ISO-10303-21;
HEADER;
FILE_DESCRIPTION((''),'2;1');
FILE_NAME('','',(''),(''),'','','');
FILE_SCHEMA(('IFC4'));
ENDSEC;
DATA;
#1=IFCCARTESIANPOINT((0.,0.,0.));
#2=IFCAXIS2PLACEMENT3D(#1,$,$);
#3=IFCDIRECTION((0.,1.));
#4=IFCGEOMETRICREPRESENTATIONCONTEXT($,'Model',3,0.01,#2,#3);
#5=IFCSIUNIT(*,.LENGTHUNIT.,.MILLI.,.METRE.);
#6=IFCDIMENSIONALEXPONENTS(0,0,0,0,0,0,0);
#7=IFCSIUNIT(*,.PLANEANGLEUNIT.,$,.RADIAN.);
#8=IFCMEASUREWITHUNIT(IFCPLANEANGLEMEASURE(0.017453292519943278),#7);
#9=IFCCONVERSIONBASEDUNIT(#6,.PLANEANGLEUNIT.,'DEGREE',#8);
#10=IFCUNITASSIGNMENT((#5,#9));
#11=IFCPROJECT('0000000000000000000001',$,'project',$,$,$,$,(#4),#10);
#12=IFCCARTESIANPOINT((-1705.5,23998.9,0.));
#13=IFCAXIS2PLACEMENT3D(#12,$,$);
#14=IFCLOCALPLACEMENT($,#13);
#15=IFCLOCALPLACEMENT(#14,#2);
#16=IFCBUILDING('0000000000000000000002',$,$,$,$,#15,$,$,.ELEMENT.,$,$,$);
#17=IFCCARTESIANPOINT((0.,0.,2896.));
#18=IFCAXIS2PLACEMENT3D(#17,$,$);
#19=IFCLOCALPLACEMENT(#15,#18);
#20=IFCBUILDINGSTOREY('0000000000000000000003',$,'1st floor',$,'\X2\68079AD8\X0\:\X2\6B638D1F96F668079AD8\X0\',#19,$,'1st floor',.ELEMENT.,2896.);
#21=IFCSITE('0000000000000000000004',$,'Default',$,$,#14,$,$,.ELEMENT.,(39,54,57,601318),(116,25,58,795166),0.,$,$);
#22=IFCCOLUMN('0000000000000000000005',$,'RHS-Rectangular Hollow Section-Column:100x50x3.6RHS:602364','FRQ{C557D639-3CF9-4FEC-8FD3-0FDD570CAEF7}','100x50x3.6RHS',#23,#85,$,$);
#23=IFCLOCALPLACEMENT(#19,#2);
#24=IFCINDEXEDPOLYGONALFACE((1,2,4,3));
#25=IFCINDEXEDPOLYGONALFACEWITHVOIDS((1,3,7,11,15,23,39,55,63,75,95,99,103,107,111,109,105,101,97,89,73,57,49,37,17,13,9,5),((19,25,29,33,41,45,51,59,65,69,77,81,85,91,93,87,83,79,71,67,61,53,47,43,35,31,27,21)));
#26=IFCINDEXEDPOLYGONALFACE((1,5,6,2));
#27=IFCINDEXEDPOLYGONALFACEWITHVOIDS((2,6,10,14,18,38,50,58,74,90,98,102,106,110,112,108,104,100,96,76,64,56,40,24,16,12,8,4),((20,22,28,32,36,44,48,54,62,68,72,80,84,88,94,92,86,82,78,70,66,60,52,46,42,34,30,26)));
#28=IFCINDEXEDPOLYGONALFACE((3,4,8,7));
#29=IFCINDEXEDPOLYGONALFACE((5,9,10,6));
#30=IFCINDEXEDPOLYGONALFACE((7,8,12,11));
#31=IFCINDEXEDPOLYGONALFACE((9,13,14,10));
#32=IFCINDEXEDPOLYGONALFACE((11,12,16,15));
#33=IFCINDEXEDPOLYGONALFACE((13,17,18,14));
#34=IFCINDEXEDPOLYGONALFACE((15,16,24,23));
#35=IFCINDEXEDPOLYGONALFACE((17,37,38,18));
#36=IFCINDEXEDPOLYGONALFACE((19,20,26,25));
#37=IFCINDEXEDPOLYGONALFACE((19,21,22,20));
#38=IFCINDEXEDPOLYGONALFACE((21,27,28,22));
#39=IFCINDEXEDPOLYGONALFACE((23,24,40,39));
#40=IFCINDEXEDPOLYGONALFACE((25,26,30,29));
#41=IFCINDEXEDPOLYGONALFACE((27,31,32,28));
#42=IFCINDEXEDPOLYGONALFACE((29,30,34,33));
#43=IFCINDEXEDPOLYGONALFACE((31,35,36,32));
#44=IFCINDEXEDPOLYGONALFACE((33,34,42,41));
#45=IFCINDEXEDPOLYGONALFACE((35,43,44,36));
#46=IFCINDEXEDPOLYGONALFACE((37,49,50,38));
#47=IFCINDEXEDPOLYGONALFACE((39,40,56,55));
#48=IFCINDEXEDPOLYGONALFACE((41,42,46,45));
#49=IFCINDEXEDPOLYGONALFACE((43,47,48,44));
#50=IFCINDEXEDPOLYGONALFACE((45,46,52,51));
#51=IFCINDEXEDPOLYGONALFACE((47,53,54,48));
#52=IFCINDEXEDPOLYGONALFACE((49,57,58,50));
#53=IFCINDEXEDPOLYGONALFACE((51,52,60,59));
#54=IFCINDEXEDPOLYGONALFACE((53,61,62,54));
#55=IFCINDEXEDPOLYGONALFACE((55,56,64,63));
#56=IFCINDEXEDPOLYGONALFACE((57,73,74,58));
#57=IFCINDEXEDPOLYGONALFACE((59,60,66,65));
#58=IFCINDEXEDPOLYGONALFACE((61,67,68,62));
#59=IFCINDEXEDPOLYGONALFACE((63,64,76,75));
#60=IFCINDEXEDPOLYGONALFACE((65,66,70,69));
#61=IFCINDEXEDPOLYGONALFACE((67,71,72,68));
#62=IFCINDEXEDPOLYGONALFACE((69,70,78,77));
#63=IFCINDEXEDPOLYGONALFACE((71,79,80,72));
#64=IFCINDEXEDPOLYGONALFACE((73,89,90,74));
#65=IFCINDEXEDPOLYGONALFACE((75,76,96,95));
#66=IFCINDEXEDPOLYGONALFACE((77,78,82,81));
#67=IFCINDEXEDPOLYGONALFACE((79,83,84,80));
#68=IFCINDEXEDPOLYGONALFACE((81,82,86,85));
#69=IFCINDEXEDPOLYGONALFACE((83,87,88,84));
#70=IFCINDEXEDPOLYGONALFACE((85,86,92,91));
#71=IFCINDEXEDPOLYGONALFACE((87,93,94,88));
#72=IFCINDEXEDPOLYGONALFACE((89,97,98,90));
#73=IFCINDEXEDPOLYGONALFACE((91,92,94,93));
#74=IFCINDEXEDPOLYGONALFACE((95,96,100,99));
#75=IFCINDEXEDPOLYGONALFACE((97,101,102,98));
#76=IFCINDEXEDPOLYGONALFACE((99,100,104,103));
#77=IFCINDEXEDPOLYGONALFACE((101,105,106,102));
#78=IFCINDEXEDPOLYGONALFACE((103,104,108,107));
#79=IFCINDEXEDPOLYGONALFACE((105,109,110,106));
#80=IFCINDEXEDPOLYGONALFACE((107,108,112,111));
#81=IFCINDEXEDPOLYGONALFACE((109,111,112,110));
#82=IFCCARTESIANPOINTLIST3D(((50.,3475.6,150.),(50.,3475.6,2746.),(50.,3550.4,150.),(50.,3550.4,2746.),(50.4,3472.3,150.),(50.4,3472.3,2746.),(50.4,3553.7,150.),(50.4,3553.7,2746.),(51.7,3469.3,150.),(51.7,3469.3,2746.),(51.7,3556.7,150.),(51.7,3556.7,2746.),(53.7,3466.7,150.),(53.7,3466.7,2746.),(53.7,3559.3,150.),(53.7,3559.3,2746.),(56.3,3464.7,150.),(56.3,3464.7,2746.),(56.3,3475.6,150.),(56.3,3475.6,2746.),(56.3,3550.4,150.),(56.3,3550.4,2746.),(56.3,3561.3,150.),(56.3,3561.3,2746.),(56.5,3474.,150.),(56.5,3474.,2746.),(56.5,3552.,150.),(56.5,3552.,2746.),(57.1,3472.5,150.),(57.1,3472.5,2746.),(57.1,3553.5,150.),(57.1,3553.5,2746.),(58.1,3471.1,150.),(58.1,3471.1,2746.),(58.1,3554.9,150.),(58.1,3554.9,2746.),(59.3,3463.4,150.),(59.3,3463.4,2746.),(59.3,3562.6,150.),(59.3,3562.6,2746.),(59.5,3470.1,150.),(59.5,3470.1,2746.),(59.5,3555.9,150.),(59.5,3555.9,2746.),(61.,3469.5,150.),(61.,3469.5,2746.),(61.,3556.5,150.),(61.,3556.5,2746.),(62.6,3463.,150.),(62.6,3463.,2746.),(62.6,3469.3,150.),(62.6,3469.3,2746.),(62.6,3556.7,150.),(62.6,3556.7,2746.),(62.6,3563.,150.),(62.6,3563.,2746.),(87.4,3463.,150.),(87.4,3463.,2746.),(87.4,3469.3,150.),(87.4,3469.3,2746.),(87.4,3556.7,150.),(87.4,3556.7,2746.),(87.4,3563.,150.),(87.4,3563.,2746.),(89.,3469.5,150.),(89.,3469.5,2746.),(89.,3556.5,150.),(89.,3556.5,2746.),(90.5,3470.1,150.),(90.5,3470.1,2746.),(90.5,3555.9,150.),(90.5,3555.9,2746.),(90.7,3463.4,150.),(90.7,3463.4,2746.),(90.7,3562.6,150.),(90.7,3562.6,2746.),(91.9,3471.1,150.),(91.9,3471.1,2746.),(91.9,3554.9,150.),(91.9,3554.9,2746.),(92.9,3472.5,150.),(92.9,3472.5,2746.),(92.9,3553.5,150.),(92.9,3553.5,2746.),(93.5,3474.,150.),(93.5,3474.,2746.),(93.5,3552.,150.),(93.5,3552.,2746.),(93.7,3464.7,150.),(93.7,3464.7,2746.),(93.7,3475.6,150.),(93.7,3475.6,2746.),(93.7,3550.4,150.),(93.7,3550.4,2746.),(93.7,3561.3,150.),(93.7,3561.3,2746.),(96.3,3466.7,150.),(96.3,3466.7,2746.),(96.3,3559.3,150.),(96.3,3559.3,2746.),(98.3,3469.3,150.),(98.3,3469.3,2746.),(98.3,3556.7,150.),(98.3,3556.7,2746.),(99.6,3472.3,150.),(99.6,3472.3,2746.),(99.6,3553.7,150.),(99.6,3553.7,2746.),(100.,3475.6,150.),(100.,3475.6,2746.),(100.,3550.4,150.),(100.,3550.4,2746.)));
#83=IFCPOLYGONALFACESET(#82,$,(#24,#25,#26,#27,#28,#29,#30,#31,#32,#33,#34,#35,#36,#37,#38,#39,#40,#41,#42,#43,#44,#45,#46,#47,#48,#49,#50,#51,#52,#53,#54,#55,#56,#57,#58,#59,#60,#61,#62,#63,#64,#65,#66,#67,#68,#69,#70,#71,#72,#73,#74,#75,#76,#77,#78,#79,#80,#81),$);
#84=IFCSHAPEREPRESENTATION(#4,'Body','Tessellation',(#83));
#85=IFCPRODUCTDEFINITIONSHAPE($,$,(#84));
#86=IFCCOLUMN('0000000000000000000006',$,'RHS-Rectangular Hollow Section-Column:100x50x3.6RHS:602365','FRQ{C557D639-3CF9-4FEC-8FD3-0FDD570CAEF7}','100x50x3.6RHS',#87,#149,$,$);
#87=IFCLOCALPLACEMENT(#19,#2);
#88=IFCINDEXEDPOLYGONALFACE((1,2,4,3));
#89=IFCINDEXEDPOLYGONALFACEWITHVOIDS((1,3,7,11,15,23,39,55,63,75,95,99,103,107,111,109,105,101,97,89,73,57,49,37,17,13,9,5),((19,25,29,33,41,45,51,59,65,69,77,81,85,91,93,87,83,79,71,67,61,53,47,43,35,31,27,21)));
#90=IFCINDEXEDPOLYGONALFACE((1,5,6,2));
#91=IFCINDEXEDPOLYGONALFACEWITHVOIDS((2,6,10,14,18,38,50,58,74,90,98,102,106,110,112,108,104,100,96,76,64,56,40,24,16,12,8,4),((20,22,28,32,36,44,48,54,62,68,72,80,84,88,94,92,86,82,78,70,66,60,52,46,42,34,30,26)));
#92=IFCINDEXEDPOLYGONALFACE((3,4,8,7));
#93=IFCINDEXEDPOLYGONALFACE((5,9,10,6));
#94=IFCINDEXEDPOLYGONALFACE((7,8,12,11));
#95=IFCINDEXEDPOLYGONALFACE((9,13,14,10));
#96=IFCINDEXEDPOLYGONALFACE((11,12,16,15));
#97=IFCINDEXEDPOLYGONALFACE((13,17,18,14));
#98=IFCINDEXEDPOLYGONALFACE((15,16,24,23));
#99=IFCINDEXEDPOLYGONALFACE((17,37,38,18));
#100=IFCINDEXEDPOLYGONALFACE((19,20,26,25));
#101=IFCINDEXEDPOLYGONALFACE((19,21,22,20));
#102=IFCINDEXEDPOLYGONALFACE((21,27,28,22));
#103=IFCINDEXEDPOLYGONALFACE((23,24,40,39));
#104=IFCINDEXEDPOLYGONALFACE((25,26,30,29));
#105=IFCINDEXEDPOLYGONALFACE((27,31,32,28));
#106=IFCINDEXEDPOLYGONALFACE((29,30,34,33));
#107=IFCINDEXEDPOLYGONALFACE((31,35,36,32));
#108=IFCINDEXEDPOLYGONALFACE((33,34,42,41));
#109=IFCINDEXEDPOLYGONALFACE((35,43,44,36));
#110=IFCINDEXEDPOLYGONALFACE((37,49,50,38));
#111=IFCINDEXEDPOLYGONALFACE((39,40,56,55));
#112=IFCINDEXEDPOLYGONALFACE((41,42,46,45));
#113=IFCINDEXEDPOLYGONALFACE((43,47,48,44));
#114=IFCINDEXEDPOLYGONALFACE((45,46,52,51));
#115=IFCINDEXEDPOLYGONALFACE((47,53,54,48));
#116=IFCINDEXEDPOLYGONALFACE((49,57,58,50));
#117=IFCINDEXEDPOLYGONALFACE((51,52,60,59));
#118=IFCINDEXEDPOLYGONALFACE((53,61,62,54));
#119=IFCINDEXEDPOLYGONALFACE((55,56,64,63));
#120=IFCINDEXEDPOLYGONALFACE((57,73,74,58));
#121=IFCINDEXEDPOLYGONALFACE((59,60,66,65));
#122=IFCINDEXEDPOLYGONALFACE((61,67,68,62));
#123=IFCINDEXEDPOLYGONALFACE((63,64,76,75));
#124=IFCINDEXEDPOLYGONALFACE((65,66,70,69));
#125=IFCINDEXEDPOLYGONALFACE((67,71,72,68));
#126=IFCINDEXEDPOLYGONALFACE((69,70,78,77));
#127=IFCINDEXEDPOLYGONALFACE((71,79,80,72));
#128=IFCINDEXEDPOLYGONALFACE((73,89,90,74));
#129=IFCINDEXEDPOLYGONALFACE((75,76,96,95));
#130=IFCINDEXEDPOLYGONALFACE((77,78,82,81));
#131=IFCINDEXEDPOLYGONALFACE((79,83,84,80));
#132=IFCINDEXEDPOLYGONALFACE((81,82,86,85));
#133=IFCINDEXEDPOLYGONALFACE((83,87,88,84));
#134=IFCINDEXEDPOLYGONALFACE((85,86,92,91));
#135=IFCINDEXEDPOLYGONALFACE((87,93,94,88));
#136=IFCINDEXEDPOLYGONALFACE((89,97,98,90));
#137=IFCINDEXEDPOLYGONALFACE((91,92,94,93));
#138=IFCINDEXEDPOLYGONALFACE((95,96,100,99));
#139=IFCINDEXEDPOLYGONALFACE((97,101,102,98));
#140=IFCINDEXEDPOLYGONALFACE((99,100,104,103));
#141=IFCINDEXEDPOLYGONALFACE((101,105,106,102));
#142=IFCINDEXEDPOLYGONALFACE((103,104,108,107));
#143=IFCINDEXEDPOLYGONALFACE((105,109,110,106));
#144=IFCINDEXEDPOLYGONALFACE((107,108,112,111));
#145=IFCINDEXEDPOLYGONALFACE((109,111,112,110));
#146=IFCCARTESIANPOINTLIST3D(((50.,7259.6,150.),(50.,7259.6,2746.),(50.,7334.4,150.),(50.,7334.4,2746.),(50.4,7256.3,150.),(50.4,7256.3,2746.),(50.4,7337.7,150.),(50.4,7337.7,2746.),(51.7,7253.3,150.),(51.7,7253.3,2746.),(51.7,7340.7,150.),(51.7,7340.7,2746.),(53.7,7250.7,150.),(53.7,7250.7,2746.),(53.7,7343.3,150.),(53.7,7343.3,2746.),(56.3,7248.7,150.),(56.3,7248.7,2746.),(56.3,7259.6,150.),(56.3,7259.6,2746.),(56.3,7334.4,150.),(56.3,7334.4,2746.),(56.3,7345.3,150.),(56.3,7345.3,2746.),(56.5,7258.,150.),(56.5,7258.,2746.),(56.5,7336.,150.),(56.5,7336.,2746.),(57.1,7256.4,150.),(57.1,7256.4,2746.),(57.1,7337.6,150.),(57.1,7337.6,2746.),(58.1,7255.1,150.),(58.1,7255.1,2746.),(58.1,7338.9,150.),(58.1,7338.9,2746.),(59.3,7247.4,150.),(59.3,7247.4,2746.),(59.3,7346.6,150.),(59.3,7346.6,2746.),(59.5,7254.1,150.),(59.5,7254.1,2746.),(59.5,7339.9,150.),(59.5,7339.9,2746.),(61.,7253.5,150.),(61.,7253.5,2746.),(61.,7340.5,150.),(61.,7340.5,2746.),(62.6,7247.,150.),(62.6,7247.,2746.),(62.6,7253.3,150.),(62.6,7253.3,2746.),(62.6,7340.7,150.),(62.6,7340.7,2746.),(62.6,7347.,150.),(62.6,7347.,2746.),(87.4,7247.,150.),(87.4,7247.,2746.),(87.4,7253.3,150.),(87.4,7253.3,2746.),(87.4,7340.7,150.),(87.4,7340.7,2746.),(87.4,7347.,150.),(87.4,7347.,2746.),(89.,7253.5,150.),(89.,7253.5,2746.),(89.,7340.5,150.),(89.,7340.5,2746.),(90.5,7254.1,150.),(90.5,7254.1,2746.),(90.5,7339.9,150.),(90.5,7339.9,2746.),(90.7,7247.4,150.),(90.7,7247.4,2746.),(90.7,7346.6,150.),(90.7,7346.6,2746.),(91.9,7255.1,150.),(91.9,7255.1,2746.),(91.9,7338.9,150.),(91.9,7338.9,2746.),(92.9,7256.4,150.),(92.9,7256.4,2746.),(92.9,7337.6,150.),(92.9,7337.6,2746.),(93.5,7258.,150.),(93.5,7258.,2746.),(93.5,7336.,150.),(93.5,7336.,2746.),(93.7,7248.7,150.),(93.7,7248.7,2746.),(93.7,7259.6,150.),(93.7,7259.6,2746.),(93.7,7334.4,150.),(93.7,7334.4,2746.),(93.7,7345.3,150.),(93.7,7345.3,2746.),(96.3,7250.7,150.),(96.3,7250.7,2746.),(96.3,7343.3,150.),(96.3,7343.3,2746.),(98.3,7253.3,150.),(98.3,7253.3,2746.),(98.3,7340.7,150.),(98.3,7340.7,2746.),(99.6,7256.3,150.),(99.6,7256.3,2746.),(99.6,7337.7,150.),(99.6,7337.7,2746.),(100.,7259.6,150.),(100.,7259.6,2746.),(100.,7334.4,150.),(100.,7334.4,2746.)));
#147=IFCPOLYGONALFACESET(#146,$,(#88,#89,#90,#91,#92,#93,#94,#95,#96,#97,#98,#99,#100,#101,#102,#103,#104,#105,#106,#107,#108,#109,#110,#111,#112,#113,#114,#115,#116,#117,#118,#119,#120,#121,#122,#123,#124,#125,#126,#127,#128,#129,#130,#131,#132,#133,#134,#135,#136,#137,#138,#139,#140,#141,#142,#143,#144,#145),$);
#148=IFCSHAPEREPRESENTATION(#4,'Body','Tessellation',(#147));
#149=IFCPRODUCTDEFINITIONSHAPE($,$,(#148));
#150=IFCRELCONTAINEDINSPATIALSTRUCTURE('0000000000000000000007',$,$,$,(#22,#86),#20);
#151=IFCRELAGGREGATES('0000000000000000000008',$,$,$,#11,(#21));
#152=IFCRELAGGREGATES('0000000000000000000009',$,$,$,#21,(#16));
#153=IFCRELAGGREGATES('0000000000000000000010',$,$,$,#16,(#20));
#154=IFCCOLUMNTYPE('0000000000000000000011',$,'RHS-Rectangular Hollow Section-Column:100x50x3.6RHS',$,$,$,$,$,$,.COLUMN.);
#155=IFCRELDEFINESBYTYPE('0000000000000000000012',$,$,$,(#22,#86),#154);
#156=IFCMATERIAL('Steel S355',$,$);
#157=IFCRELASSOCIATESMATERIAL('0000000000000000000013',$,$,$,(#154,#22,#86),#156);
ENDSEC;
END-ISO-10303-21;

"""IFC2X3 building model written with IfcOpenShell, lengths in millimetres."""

from ifc_helpers import new_model, entity, si_unit, converted_unit, direction, frame, origin, origin_2d, place, context, project, spatial, hollow_rectangle, extrude, clip, halfspace, material, type_object, element, save


model = new_model("IFC2X3")

# Units and contexts
model_context = context("Model", 3, precision=0.01, world=origin(), true_north=direction((0.0, 1.0)))
ifc_project = project(units=[si_unit("LENGTHUNIT", "METRE", prefix="MILLI"), converted_unit("PLANEANGLEUNIT", "DEGREE", entity("IfcPlaneAngleMeasure", 0.017453292519943278), si_unit("PLANEANGLEUNIT", "RADIAN"), dimensions=[0, 0, 0, 0, 0, 0, 0])], contexts=[model_context])

# Site, building, storey
site_placement = place(None, frame((-1705.5, 23998.9, 0.0)))
site = spatial("IfcSite", under=ifc_project, at=site_placement, Name="Default", CompositionType="ELEMENT", RefLatitude=(39, 54, 57, 601318), RefLongitude=(116, 25, 58, 795166), RefElevation=0.0)
building_placement = place(site_placement, origin())
building = spatial("IfcBuilding", under=site, at=building_placement, CompositionType="ELEMENT")
storey_placement = place(building_placement, frame((0.0, 0.0, 2896.0)))
storey = spatial("IfcBuildingStorey", under=building, at=storey_placement, Name="1st floor", ObjectType="标高:正负零标高", LongName="1st floor", CompositionType="ELEMENT", Elevation=2896.0)

# Shared definitions
ifc_material_1 = material(Name="Steel S355")

# Columns
column_type_1 = type_object("IfcColumnType", Name="RHS-Rectangular Hollow Section-Column:100x50x3.6RHS", PredefinedType="COLUMN", material=ifc_material_1)
column_1_placement = place(storey_placement, frame((75.0, 3513.0, 2746.0), z_axis=(0.0, 0.0, 1.0), x_axis=(-1.0, 0.0, 0.0)))
element("IfcColumn", 1, at=column_1_placement, inside=storey, type_object=column_type_1, material=ifc_material_1, Name="RHS-Rectangular Hollow Section-Column:100x50x3.6RHS:602364", Description="FRQ{C557D639-3CF9-4FEC-8FD3-0FDD570CAEF7}", ObjectType="100x50x3.6RHS", context=model_context, shape_type="Clipping", body=[
    clip(extrude(hollow_rectangle(XDim=50.0, YDim=100.0, WallThickness=6.3, InnerFilletRadius=6.3, OuterFilletRadius=12.6, at=origin_2d()), origin(), (0.0, 0.0, -1.0), 2651.9), halfspace(frame((75.0, 3513.0, -2596.0), z_axis=(0.0, 0.0, 1.0), x_axis=(-1.0, 0.0, 0.0)), True)),
])
column_2_placement = place(storey_placement, frame((75.0, 7297.0, 2746.0), z_axis=(0.0, 0.0, 1.0), x_axis=(-1.0, 0.0, 0.0)))
element("IfcColumn", 2, at=column_2_placement, inside=storey, type_object=column_type_1, material=ifc_material_1, Name="RHS-Rectangular Hollow Section-Column:100x50x3.6RHS:602365", Description="FRQ{C557D639-3CF9-4FEC-8FD3-0FDD570CAEF7}", ObjectType="100x50x3.6RHS", context=model_context, shape_type="Clipping", body=[
    clip(extrude(hollow_rectangle(XDim=50.0, YDim=100.0, WallThickness=6.3, InnerFilletRadius=6.3, OuterFilletRadius=12.6, at=origin_2d()), origin(), (0.0, 0.0, -1.0), 2651.9), halfspace(frame((75.0, 7297.0, -2596.0), z_axis=(0.0, 0.0, 1.0), x_axis=(-1.0, 0.0, 0.0)), True)),
])

save(model, "model.ifc")
